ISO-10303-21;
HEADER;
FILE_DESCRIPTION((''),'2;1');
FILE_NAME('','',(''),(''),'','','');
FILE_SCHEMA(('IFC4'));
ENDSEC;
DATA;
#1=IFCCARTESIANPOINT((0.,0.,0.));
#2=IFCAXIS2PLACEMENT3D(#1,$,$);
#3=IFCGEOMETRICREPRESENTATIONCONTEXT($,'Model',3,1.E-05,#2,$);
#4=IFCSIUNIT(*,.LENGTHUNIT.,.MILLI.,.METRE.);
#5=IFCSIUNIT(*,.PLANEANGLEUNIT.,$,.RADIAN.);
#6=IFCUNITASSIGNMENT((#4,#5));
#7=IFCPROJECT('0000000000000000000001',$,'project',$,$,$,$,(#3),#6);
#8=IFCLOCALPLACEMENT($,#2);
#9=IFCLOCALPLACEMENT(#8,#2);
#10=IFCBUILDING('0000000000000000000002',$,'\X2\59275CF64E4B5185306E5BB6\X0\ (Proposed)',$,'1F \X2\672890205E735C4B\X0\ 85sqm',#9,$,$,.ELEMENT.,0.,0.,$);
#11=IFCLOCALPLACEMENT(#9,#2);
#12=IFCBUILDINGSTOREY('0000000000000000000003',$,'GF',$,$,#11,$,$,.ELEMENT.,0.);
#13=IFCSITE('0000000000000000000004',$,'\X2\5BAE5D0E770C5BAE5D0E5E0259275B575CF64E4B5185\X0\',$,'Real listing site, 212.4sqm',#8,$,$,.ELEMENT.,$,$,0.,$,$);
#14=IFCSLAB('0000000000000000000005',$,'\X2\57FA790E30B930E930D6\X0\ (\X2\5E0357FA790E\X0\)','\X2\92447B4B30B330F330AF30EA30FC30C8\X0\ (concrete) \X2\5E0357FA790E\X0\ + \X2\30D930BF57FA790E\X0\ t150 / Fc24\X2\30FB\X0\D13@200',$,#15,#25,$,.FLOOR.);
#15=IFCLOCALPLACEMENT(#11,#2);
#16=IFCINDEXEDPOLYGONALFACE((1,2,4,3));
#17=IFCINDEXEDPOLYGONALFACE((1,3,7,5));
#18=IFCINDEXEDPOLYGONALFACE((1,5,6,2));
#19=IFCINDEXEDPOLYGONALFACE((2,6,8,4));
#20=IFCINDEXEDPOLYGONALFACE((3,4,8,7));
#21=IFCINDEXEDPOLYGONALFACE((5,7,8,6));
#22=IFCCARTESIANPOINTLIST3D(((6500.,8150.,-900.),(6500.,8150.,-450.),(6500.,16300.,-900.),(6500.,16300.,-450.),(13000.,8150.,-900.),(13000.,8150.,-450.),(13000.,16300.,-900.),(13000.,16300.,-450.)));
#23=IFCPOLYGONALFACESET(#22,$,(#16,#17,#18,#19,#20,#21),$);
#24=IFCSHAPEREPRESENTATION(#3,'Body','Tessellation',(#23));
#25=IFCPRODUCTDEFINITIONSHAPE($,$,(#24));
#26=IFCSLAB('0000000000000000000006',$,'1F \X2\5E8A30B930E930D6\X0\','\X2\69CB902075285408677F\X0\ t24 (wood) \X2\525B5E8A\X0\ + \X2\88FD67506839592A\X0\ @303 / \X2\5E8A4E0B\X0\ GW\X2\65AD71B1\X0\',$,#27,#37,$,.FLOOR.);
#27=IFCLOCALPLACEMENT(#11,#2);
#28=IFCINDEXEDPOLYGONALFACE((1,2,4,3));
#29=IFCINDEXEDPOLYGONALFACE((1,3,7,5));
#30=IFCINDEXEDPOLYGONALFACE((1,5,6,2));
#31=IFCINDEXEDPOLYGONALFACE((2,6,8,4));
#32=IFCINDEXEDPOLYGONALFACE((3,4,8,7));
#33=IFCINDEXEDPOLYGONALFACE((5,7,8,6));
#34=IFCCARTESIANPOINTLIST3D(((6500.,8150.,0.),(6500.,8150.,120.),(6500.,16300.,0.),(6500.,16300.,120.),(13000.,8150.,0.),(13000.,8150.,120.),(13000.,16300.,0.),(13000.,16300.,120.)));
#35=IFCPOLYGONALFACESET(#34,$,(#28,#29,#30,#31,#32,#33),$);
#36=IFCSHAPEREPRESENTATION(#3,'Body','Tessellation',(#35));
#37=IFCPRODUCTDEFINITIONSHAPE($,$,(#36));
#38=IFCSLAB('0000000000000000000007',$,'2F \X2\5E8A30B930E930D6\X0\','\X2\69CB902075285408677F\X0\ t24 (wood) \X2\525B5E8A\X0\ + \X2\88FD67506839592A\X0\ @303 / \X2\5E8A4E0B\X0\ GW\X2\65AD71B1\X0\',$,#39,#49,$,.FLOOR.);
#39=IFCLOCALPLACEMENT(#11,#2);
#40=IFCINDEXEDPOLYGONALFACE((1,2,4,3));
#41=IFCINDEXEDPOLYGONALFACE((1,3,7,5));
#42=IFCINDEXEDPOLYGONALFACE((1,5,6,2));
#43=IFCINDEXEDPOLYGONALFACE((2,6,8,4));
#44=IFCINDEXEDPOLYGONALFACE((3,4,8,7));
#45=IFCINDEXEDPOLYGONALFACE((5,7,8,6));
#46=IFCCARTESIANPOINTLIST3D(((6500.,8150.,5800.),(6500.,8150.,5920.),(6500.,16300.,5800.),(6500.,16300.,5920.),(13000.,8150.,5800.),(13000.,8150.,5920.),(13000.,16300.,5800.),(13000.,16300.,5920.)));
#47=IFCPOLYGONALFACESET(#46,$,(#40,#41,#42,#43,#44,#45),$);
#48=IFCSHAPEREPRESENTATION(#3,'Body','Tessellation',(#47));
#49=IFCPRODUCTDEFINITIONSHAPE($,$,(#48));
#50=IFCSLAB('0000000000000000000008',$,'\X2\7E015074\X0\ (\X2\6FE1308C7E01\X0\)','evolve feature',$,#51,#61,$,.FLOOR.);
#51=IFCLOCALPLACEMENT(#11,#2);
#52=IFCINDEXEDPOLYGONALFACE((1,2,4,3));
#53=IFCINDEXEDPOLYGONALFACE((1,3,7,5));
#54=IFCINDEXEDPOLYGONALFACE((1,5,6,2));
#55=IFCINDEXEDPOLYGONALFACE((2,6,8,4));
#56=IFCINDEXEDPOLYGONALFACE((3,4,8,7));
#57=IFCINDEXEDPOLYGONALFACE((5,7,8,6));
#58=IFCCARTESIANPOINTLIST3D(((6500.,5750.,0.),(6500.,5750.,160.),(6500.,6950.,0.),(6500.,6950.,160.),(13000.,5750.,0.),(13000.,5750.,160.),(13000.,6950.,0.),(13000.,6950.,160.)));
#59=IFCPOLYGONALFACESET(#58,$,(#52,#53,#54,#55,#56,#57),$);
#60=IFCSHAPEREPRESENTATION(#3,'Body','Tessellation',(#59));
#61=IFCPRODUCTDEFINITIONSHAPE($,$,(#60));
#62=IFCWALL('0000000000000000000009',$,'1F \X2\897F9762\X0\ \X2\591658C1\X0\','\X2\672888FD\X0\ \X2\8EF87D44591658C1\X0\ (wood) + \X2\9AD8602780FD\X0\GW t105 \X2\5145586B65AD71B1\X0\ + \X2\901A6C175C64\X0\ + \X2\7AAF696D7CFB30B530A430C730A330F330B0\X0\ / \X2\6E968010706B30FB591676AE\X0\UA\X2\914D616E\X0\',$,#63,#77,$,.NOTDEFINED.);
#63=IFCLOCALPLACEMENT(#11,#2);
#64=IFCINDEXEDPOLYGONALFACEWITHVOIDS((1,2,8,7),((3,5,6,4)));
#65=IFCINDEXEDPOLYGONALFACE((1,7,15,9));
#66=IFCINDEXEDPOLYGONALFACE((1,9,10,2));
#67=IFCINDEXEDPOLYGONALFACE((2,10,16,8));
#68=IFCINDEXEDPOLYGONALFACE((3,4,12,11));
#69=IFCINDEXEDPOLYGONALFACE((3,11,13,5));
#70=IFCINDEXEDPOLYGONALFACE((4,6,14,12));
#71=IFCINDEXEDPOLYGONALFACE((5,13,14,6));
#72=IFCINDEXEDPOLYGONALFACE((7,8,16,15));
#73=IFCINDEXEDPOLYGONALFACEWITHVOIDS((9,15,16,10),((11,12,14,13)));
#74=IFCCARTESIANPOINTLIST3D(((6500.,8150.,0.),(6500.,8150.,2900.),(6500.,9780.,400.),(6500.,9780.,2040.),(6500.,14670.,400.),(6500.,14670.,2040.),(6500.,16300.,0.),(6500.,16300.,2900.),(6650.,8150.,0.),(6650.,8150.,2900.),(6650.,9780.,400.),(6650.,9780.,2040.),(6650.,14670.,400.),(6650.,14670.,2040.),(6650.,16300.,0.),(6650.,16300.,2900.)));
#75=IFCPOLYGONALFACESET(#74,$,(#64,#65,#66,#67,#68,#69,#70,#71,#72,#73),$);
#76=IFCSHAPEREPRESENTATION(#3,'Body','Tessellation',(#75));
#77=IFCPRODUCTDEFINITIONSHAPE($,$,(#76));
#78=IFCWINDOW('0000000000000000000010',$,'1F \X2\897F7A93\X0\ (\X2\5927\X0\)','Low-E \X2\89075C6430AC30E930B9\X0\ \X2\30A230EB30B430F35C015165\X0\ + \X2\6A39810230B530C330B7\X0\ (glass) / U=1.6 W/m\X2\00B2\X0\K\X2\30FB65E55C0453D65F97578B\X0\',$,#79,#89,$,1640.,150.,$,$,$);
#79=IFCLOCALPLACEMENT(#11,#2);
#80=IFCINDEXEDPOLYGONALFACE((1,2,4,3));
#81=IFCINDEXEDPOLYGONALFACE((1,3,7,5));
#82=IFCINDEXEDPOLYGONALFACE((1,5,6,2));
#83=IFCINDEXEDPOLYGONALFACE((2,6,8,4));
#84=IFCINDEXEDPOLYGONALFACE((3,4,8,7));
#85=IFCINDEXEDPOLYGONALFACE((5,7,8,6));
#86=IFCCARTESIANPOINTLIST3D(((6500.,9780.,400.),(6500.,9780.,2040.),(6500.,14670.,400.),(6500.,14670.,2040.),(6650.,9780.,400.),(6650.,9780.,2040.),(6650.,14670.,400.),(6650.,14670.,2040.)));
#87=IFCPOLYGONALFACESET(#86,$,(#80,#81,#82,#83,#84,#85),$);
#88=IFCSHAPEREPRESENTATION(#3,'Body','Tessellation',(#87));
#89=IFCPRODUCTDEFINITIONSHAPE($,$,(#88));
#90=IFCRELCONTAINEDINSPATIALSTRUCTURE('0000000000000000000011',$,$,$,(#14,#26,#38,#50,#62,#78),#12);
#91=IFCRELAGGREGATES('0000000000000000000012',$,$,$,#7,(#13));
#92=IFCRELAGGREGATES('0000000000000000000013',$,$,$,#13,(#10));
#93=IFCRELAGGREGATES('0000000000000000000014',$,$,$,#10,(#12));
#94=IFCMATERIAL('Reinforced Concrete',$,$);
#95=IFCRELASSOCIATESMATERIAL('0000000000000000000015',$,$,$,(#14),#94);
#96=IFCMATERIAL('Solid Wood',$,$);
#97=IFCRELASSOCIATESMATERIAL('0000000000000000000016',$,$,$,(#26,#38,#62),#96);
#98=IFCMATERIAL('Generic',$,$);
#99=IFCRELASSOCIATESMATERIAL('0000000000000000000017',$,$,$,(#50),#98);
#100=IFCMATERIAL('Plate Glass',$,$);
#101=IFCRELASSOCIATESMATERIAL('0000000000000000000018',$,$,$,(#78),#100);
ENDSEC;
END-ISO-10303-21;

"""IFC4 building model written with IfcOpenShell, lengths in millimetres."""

from ifc_helpers import new_model, si_unit, frame, frame_2d, origin, place, context, project, spatial, rectangle, extrude, material, element, fill, save


model = new_model("IFC4")

# Units and contexts
model_context = context("Model", 3, precision=1e-05, world=origin())
ifc_project = project(units=[si_unit("LENGTHUNIT", "METRE", prefix="MILLI"), si_unit("PLANEANGLEUNIT", "RADIAN")], contexts=[model_context])

# Site, building, storey
site_placement = place(None, origin())
site = spatial("IfcSite", under=ifc_project, at=site_placement, Name="宮崎県宮崎市大字島之内", ObjectType="Real listing site, 212.4sqm", CompositionType="ELEMENT", RefElevation=0.0)
building_placement = place(site_placement, origin())
building = spatial("IfcBuilding", under=site, at=building_placement, Name="大島之内の家 (Proposed)", ObjectType="1F 木造平屋 85sqm", CompositionType="ELEMENT", ElevationOfRefHeight=0.0, ElevationOfTerrain=0.0)
storey_placement = place(building_placement, origin())
storey = spatial("IfcBuildingStorey", under=building, at=storey_placement, Name="GF", CompositionType="ELEMENT", Elevation=0.0)

# Slabs
ifc_material_1 = material(Name="Reinforced Concrete")
slab_1_placement = place(storey_placement, frame((3250.0, 4075.0, -450.0)))
element("IfcSlab", 1, at=slab_1_placement, inside=storey, material=ifc_material_1, Name="基礎スラブ (布基礎)", Description="鉄筋コンクリート (concrete) 布基礎 + ベタ基礎 t150 / Fc24・D13@200", PredefinedType="FLOOR", context=model_context, shape_type="SweptSolid", body=[
    extrude(rectangle(XDim=6500.0, YDim=8150.0, at=frame_2d((3250.0, 4075.0))), frame((3250.0, 4075.0, -450.0)), (0.0, 0.0, 1.0), 450.0),
])
ifc_material_2 = material(Name="Solid Wood")
slab_2_placement = place(storey_placement, frame((3250.0, 4075.0, 0.0)))
element("IfcSlab", 2, at=slab_2_placement, inside=storey, material=ifc_material_2, Name="1F 床スラブ", Description="構造用合板 t24 (wood) 剛床 + 製材根太 @303 / 床下 GW断熱", PredefinedType="FLOOR", context=model_context, shape_type="SweptSolid", body=[
    extrude(rectangle(XDim=6500.0, YDim=8150.0, at=frame_2d((3250.0, 4075.0))), frame((3250.0, 4075.0, 0.0)), (0.0, 0.0, 1.0), 120.0),
])
slab_3_placement = place(storey_placement, frame((3250.0, 4075.0, 2900.0)))
element("IfcSlab", 3, at=slab_3_placement, inside=storey, material=ifc_material_2, Name="2F 床スラブ", Description="構造用合板 t24 (wood) 剛床 + 製材根太 @303 / 床下 GW断熱", PredefinedType="FLOOR", context=model_context, shape_type="SweptSolid", body=[
    extrude(rectangle(XDim=6500.0, YDim=8150.0, at=frame_2d((3250.0, 4075.0))), frame((3250.0, 4075.0, 2900.0)), (0.0, 0.0, 1.0), 120.0),
])
ifc_material_3 = material(Name="Generic")
slab_4_placement = place(storey_placement, frame((3250.0, 2875.0, 0.0)))
element("IfcSlab", 4, at=slab_4_placement, inside=storey, material=ifc_material_3, Name="縁側 (濡れ縁)", Description="evolve feature", PredefinedType="FLOOR", context=model_context, shape_type="SweptSolid", body=[
    extrude(rectangle(XDim=6500.0, YDim=1200.0, at=frame_2d((3250.0, 600.0))), frame((3250.0, 2875.0, 0.0)), (0.0, 0.0, 1.0), 160.0),
])

# Shared definitions
ifc_material_4 = material(Name="Plate Glass")

# Wall, opening, window
wall_1_placement = place(storey_placement, frame((3250.0, 4075.0, 0.0)))
wall_1 = element("IfcWall", 5, at=wall_1_placement, inside=storey, material=ifc_material_2, Name="1F 西面 外壁", Description="木製 軸組外壁 (wood) + 高性能GW t105 充填断熱 + 通気層 + 窯業系サイディング / 準耐火・外皮UA配慮", PredefinedType="NOTDEFINED", context=model_context, shape_type="SweptSolid", body=[
    extrude(rectangle(XDim=150.0, YDim=8150.0, at=frame_2d((75.0, 4075.0))), frame((3250.0, 4075.0, 0.0)), (0.0, 0.0, 1.0), 2900.0),
])
opening_1_placement = place(storey_placement, frame((3250.0, 4890.0, 200.0)))
opening_1 = element("IfcOpeningElement", 6, at=opening_1_placement, cuts=wall_1, PredefinedType="NOTDEFINED", context=model_context, shape_type="SweptSolid", body=[
    extrude(rectangle(XDim=150.0, YDim=4890.0, at=frame_2d((75.0, 2445.0))), frame((3250.0, 4890.0, 200.0)), (0.0, 0.0, 1.0), 1640.0),
])
window_1_placement = place(storey_placement, frame((3250.0, 4890.0, 200.0)))
window_1 = element("IfcWindow", 7, at=window_1_placement, inside=storey, material=ifc_material_4, Name="1F 西窓 (大)", Description="Low-E 複層ガラス アルゴン封入 + 樹脂サッシ (glass) / U=1.6 W/m²K・日射取得型", OverallHeight=1640.0, OverallWidth=150.0, context=model_context, shape_type="SweptSolid", body=[
    extrude(rectangle(XDim=150.0, YDim=4890.0, at=frame_2d((75.0, 2445.0))), frame((3250.0, 4890.0, 200.0)), (0.0, 0.0, 1.0), 1640.0),
])
fill(opening_1, window_1)

save(model, "model.ifc")
